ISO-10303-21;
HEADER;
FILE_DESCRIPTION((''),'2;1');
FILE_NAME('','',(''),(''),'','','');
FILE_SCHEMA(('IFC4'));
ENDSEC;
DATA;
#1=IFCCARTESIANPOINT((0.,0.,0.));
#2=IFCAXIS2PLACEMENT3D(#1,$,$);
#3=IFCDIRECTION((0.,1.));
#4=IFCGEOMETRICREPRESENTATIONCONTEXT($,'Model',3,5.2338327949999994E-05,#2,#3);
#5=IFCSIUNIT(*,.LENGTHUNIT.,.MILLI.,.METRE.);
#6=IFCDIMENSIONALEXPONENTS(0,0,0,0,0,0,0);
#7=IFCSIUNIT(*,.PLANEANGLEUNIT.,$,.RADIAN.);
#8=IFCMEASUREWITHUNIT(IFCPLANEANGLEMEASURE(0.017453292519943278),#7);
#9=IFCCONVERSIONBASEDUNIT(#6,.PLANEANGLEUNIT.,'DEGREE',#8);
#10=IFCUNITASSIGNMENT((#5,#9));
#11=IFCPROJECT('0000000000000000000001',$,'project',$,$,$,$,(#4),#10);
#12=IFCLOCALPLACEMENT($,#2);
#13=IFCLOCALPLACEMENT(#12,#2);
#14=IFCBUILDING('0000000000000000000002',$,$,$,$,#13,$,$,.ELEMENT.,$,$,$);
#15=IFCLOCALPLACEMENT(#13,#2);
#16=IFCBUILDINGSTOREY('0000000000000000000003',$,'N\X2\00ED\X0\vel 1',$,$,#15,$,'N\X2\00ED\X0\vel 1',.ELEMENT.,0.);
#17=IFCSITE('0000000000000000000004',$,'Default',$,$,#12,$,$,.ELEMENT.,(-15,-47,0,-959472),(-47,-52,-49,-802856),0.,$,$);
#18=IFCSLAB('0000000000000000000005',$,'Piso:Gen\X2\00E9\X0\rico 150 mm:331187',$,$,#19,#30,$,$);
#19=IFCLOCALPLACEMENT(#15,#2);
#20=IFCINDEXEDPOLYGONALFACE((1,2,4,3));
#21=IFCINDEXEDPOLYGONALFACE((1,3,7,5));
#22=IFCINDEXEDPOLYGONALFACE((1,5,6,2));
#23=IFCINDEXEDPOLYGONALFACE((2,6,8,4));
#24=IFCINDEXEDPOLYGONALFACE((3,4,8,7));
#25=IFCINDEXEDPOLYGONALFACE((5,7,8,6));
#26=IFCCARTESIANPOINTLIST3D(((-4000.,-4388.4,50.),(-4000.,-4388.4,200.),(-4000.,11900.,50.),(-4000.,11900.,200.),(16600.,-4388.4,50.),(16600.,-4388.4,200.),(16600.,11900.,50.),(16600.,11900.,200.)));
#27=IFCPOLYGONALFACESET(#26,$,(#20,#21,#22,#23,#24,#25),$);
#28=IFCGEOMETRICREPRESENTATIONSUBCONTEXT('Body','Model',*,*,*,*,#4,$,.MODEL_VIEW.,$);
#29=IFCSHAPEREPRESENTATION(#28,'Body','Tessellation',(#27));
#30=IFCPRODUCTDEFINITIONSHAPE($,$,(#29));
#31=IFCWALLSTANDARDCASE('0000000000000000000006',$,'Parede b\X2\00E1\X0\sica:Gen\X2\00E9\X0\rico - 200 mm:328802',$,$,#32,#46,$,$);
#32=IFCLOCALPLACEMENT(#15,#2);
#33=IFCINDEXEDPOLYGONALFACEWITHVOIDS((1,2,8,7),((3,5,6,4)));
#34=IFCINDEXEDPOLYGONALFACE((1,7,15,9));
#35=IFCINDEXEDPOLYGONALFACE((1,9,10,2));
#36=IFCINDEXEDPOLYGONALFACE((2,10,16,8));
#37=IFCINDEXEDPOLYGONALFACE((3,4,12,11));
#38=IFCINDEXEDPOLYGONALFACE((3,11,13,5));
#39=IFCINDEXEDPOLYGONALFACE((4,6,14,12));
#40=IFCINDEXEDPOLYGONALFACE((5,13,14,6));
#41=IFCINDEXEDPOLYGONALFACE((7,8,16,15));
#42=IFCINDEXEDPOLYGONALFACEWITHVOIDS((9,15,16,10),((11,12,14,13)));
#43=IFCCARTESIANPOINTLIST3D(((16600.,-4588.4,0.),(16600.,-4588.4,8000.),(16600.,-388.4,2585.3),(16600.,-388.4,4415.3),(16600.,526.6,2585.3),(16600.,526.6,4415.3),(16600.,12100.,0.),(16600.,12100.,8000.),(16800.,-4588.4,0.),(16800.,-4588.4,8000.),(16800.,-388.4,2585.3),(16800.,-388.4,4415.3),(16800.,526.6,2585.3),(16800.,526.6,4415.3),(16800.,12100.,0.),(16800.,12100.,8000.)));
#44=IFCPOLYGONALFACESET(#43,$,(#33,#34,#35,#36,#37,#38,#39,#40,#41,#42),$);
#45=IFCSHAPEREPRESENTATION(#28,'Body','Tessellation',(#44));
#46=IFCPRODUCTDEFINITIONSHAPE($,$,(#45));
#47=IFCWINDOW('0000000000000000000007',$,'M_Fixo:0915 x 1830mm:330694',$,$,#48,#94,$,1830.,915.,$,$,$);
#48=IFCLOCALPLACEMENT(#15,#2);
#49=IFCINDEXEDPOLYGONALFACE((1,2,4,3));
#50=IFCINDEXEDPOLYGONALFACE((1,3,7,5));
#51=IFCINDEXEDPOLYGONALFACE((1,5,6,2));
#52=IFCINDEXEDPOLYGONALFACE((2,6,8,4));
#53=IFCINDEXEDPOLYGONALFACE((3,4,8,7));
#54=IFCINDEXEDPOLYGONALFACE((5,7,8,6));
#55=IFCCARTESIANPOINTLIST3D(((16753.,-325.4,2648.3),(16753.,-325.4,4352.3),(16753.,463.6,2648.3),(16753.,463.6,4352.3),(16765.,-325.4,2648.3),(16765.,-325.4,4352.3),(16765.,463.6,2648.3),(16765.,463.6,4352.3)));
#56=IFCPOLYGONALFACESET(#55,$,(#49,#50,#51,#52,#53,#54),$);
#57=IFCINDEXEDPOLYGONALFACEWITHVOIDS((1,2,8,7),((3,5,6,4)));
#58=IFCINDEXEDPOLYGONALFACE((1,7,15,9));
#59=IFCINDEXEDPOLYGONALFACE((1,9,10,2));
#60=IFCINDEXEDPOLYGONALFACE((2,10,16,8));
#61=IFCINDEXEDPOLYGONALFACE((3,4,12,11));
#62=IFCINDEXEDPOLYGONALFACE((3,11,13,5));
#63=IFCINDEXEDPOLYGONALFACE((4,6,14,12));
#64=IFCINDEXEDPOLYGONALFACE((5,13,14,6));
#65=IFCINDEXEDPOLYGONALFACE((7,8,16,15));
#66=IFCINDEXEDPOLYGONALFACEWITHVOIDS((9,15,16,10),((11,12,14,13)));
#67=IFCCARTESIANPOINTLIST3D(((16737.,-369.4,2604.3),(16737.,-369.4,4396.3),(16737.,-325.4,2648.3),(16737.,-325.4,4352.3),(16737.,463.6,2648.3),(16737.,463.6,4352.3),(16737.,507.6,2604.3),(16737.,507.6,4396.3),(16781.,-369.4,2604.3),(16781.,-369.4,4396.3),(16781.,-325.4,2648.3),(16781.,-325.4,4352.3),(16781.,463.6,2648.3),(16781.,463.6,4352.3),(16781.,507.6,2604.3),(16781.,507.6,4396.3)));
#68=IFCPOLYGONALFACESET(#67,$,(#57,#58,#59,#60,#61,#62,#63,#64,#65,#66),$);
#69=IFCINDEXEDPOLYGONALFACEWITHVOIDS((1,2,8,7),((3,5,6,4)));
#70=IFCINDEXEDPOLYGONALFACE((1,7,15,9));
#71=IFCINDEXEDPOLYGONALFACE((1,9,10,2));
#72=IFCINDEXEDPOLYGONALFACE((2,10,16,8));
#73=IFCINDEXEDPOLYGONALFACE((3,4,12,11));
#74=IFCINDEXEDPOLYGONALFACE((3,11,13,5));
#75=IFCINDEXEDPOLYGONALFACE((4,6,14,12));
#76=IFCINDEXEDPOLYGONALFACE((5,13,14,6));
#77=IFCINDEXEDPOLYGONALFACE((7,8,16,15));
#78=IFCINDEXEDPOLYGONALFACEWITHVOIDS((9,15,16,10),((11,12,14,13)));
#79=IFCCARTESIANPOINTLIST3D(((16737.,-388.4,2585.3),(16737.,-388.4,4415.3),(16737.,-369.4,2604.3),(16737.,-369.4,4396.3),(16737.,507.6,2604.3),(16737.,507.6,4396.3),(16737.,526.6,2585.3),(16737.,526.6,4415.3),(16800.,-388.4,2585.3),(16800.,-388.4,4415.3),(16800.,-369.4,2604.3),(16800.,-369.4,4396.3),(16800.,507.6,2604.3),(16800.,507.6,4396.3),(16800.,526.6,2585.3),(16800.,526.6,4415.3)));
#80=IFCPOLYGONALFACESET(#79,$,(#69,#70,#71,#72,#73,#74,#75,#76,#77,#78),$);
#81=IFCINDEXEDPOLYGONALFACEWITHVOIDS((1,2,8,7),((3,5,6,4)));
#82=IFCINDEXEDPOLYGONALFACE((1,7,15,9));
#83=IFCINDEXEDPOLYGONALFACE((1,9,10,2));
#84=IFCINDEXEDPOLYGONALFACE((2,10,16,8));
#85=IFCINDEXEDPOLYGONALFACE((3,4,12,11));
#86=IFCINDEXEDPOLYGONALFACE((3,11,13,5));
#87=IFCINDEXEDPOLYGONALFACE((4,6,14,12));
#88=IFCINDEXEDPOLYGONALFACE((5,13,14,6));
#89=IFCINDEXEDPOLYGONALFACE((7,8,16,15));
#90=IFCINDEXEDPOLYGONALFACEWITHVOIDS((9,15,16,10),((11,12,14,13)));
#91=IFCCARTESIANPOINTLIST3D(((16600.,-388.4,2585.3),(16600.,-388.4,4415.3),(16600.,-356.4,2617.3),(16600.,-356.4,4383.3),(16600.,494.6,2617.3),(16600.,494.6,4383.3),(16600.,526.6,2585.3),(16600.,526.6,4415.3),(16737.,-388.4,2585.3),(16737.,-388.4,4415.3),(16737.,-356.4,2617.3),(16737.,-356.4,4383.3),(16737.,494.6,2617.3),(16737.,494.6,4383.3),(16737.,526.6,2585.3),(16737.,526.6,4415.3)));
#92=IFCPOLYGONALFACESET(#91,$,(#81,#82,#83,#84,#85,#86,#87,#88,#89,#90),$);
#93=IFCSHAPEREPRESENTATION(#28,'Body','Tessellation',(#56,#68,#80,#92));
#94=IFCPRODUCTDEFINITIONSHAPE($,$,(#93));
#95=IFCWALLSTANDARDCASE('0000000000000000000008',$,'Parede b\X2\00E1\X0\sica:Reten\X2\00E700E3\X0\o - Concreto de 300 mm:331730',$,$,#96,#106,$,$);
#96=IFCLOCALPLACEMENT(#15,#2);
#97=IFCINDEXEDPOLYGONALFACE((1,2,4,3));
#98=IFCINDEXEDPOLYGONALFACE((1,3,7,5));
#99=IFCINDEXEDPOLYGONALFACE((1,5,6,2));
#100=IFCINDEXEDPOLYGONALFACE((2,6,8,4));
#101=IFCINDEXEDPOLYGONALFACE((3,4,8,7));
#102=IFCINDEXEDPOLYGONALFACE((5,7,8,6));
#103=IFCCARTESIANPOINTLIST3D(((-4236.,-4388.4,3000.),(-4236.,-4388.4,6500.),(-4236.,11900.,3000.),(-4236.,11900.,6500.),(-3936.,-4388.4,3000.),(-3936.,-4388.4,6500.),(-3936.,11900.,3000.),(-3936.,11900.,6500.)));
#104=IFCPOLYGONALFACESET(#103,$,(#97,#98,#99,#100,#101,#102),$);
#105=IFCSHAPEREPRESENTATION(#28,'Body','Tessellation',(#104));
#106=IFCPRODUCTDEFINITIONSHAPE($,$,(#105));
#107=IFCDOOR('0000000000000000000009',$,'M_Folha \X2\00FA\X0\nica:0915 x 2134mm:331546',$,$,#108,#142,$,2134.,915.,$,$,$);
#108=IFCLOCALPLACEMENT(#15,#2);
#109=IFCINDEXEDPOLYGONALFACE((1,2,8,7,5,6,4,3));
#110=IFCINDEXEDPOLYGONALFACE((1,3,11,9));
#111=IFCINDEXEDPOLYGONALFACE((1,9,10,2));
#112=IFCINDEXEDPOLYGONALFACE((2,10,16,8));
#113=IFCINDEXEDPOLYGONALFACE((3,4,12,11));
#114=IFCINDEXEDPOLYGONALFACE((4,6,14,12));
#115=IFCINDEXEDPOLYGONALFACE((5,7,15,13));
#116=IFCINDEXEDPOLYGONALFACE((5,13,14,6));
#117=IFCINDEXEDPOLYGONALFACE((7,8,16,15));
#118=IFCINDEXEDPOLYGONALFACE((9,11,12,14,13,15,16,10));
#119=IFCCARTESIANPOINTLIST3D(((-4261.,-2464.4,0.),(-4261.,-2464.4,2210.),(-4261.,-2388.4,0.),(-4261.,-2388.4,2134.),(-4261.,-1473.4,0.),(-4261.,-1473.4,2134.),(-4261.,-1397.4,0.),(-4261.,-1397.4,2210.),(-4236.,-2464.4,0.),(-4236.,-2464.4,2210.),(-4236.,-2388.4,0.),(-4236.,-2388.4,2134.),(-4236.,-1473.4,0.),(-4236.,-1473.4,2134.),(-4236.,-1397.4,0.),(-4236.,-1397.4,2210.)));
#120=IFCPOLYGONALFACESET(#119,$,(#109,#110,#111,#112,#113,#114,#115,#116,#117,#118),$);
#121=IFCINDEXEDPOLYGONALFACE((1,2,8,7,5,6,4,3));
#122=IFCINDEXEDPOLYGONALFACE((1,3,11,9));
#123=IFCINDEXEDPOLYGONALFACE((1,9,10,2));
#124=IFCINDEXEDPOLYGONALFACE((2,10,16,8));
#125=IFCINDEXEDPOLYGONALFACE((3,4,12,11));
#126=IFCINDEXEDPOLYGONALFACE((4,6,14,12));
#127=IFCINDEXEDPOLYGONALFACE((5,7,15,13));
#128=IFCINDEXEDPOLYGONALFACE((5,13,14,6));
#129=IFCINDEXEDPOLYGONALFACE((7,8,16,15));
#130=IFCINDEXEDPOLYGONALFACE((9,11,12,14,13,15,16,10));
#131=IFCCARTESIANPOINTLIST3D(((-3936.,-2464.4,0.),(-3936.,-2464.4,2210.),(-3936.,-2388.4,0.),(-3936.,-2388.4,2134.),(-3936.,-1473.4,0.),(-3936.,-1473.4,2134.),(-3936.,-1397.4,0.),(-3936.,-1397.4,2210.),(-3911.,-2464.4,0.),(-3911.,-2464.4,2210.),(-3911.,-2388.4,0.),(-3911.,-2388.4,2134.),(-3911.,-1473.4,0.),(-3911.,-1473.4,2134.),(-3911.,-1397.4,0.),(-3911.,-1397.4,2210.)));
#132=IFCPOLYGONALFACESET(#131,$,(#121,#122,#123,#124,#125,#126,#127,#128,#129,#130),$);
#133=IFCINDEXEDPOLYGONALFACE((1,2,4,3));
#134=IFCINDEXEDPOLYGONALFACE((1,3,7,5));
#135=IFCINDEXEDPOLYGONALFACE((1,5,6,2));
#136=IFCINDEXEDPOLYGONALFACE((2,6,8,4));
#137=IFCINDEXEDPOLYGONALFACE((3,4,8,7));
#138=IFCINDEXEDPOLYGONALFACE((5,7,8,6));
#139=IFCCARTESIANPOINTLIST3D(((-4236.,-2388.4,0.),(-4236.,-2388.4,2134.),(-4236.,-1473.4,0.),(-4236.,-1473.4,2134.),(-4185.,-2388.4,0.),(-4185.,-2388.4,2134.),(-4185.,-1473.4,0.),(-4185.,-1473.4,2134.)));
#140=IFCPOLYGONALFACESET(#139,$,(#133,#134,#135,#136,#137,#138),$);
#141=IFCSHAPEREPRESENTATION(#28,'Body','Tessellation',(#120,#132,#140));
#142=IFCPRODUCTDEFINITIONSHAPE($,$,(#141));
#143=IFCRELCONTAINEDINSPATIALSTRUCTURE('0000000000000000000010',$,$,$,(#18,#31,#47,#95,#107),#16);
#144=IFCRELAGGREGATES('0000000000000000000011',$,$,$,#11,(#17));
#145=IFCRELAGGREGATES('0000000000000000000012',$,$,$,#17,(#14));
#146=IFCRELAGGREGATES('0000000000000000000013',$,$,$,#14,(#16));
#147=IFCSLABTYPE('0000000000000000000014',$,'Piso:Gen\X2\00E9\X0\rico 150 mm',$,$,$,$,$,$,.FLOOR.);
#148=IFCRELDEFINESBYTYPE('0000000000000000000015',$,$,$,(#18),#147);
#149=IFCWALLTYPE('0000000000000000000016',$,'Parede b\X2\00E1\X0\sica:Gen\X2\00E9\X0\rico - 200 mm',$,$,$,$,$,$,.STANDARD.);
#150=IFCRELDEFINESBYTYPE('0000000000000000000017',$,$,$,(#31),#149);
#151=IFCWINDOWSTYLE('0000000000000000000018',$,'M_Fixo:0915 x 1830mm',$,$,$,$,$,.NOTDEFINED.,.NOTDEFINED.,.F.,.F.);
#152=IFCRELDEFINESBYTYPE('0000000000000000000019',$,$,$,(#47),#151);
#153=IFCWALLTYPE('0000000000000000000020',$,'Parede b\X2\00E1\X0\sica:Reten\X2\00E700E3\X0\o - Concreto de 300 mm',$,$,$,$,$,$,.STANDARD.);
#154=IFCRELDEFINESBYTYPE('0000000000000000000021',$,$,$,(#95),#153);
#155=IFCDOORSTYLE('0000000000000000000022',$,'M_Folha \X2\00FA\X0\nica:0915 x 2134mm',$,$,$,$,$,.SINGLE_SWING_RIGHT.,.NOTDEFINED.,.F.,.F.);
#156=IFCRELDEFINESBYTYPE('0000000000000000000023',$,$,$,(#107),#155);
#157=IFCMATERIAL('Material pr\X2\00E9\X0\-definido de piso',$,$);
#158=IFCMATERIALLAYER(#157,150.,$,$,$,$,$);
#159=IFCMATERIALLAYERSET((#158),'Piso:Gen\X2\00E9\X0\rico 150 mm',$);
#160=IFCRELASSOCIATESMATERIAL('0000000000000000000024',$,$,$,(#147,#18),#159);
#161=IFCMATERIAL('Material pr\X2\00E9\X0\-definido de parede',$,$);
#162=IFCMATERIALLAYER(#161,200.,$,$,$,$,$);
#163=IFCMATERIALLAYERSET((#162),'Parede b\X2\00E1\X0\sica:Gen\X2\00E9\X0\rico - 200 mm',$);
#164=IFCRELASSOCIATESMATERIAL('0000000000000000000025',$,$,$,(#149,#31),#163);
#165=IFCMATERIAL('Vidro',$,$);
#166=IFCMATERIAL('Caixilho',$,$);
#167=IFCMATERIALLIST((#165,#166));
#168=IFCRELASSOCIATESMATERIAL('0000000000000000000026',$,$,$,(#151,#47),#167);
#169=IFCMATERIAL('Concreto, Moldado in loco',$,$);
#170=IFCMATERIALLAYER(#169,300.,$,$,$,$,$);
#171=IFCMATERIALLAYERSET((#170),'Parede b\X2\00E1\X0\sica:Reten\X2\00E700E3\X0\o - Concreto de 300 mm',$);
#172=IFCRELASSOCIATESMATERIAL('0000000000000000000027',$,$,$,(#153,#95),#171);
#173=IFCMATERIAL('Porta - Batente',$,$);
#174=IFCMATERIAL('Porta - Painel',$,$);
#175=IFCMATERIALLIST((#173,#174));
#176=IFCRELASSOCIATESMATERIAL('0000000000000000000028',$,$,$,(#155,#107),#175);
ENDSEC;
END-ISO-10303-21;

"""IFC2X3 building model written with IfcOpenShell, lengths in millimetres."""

from ifc_helpers import new_model, entity, si_unit, converted_unit, direction, frame, frame_2d, origin, place, context, subcontext, project, spatial, polyline, rectangle, outline, extrude, source, transform, mapped, material, material_list, layer, layer_set, layer_usage, type_object, type_shapes, element, fill, save


model = new_model("IFC2X3")

# Units and contexts
model_context = context("Model", 3, precision=5.2338327949999994e-05, world=origin(), true_north=direction((0.0, 1.0)))
body_context = subcontext(model_context, "Body", "Model", "MODEL_VIEW")
ifc_project = project(units=[si_unit("LENGTHUNIT", "METRE", prefix="MILLI"), converted_unit("PLANEANGLEUNIT", "DEGREE", entity("IfcPlaneAngleMeasure", 0.017453292519943278), si_unit("PLANEANGLEUNIT", "RADIAN"), dimensions=[0, 0, 0, 0, 0, 0, 0])], contexts=[model_context])

# Site, building, storey
site_placement = place(None, origin())
site = spatial("IfcSite", under=ifc_project, at=site_placement, Name="Default", CompositionType="ELEMENT", RefLatitude=(-15, -47, 0, -959472), RefLongitude=(-47, -52, -49, -802856), RefElevation=0.0)
building_placement = place(site_placement, origin())
building = spatial("IfcBuilding", under=site, at=building_placement, CompositionType="ELEMENT")
storey_placement = place(building_placement, origin())
storey = spatial("IfcBuildingStorey", under=building, at=storey_placement, Name="Nível 1", LongName="Nível 1", CompositionType="ELEMENT", Elevation=0.0)

# Slab
ifc_material_1 = material(Name="Material pré-definido de piso")
ifc_layer_1 = layer(ifc_material_1, 150.0)
ifc_layer_set_1 = layer_set([ifc_layer_1], Name="Piso:Genérico 150 mm")
ifc_layer_usage_1 = layer_usage(ifc_layer_set_1, "AXIS3", "POSITIVE", 0.0)
slab_type = type_object("IfcSlabType", Name="Piso:Genérico 150 mm", PredefinedType="FLOOR", material=ifc_layer_set_1)
slab_placement = place(storey_placement, origin())
element("IfcSlab", 1, at=slab_placement, inside=storey, type_object=slab_type, material=ifc_layer_usage_1, Name="Piso:Genérico 150 mm:331187", context=body_context, shape_type="SweptSolid", body=[
    extrude(rectangle(XDim=16288.4, YDim=20600.0, at=frame_2d((0.0, 0.0), x_axis=(1.0, 0.0))), frame((6300.0, 3755.8, 200.0), z_axis=(0.0, 0.0, -1.0), x_axis=(0.0, 1.0, 0.0)), (0.0, 0.0, 1.0), 150.0),
])

# Wall, opening, window
ifc_material_2 = material(Name="Material pré-definido de parede")
ifc_layer_2 = layer(ifc_material_2, 200.0)
ifc_layer_set_2 = layer_set([ifc_layer_2], Name="Parede básica:Genérico - 200 mm")
ifc_layer_usage_2 = layer_usage(ifc_layer_set_2, "AXIS2", "NEGATIVE", 100.0)
wall_type_1 = type_object("IfcWallType", Name="Parede básica:Genérico - 200 mm", PredefinedType="STANDARD", material=ifc_layer_set_2)
wall_1_placement = place(storey_placement, frame((16700.0, -4588.4, 0.0), z_axis=(0.0, 0.0, 1.0), x_axis=(0.0, 1.0, 0.0)))
wall_1 = element("IfcWallStandardCase", 2, at=wall_1_placement, inside=storey, type_object=wall_type_1, material=ifc_layer_usage_2, Name="Parede básica:Genérico - 200 mm:328802", context=body_context, shape_type="SweptSolid", body=[
    extrude(rectangle(XDim=16688.4, YDim=200.0, at=frame_2d((8344.2, 0.0), x_axis=(-1.0, 0.0))), origin(), (0.0, 0.0, 1.0), 8000.0),
])
opening_1_placement = place(wall_1_placement, frame((5115.0, 100.0, 2585.3)))
opening_1 = element("IfcOpeningElement", 3, at=opening_1_placement, cuts=wall_1, ObjectType="Opening", context=body_context, shape_type="SweptSolid", body=[
    extrude(rectangle(XDim=1830.0, YDim=915.0, at=frame_2d((915.0, 457.5), x_axis=(1.0, 0.0))), frame((0.0, 0.0, 0.0), z_axis=(0.0, -1.0, 0.0), x_axis=(0.0, 0.0, 1.0)), (0.0, 0.0, 1.0), 200.0),
])
ifc_material_3 = material(Name="Vidro")
ifc_material_4 = material(Name="Caixilho")
ifc_material_list_1 = material_list([ifc_material_3, ifc_material_4])
window_style = type_object("IfcWindowStyle", Name="M_Fixo:0915 x 1830mm", ConstructionType="NOTDEFINED", OperationType="NOTDEFINED", ParameterTakesPrecedence=False, Sizeable=False, material=ifc_material_list_1)
shared_shape_1 = source(origin(), body_context, "Body", "SweptSolid", [
    extrude(rectangle(XDim=12.0, YDim=789.0, at=frame_2d((0.0, 0.0), x_axis=(1.0, 0.0))), frame((457.5, 159.0, 63.0), z_axis=(0.0, 0.0, 1.0), x_axis=(0.0, -1.0, 0.0)), (0.0, 0.0, 1.0), 1704.0),
    extrude(outline(polyline([(-438.5, -896.0), (438.5, -896.0), (438.5, 896.0), (-438.5, 896.0), (-438.5, -896.0)]), holes=[polyline([(-394.5, -852.0), (-394.5, 852.0), (394.5, 852.0), (394.5, -852.0), (-394.5, -852.0)])]), frame((457.5, 137.0, 915.0), z_axis=(0.0, 1.0, 0.0), x_axis=(1.0, 0.0, 0.0)), (0.0, 0.0, 1.0), 44.0),
    extrude(outline(polyline([(-457.5, -915.0), (457.5, -915.0), (457.5, 915.0), (-457.5, 915.0), (-457.5, -915.0)]), holes=[polyline([(-438.5, -896.0), (-438.5, 896.0), (438.5, 896.0), (438.5, -896.0), (-438.5, -896.0)])]), frame((457.5, 137.0, 915.0), z_axis=(0.0, 1.0, 0.0), x_axis=(1.0, 0.0, 0.0)), (0.0, 0.0, 1.0), 63.0),
    extrude(outline(polyline([(-457.5, -915.0), (457.5, -915.0), (457.5, 915.0), (-457.5, 915.0), (-457.5, -915.0)]), holes=[polyline([(-425.5, -883.0), (-425.5, 883.0), (425.5, 883.0), (425.5, -883.0), (-425.5, -883.0)])]), frame((457.5, 0.0, 915.0), z_axis=(0.0, 1.0, 0.0), x_axis=(1.0, 0.0, 0.0)), (0.0, 0.0, 1.0), 137.0),
])
type_shapes(window_style, [shared_shape_1])
window_placement = place(opening_1_placement, frame((0.0, 0.0, 0.0), z_axis=(0.0, 0.0, 1.0), x_axis=(-1.0, 0.0, 0.0)))
window = element("IfcWindow", 4, at=window_placement, inside=storey, type_object=window_style, material=ifc_material_list_1, Name="M_Fixo:0915 x 1830mm:330694", OverallHeight=1830.0, OverallWidth=915.0, context=body_context, shape_type="MappedRepresentation", body=[
    mapped(shared_shape_1, transform((0.0, 0.0, 0.0), scale=1.0)),
])
fill(opening_1, window)

# Wall, openings, door
ifc_material_5 = material(Name="Concreto, Moldado in loco")
ifc_layer_3 = layer(ifc_material_5, 300.0)
ifc_layer_set_3 = layer_set([ifc_layer_3], Name="Parede básica:Retenção - Concreto de 300 mm")
ifc_layer_usage_3 = layer_usage(ifc_layer_set_3, "AXIS2", "NEGATIVE", 150.0)
wall_type_2 = type_object("IfcWallType", Name="Parede básica:Retenção - Concreto de 300 mm", PredefinedType="STANDARD", material=ifc_layer_set_3)
wall_2_placement = place(storey_placement, frame((-4086.0, 11900.0, 3000.0), z_axis=(0.0, 0.0, 1.0), x_axis=(0.0, -1.0, 0.0)))
wall_2 = element("IfcWallStandardCase", 5, at=wall_2_placement, inside=storey, type_object=wall_type_2, material=ifc_layer_usage_3, Name="Parede básica:Retenção - Concreto de 300 mm:331730", context=body_context, shape_type="SweptSolid", body=[
    extrude(rectangle(XDim=16288.4, YDim=300.0, at=frame_2d((8144.2, 0.0), x_axis=(-1.0, 0.0))), origin(), (0.0, 0.0, 1.0), 3500.0),
])
opening_2_placement = place(wall_2_placement, frame((14288.4, 150.0, -3000.0)))
opening_2 = element("IfcOpeningElement", 6, at=opening_2_placement, cuts=wall_2, ObjectType="Opening", context=body_context, shape_type="SweptSolid", body=[
    extrude(rectangle(XDim=915.0, YDim=2134.0, at=frame_2d((1067.0, 457.5), x_axis=(0.0, 1.0))), frame((0.0, 0.0, 0.0), z_axis=(0.0, -1.0, 0.0), x_axis=(0.0, 0.0, 1.0)), (0.0, 0.0, 1.0), 300.0),
])
opening_3_placement = place(wall_2_placement, frame((11900.0, 4086.0, -3000.0), z_axis=(0.0, 0.0, 1.0), x_axis=(0.0, 1.0, 0.0)))
element("IfcOpeningElement", 7, at=opening_3_placement, cuts=wall_2, ObjectType="Opening", context=body_context, shape_type="SweptSolid", body=[
    extrude(rectangle(XDim=2134.0, YDim=915.0, at=frame_2d((0.0, 0.0), x_axis=(0.0, 1.0))), frame((-5460.0, -1930.9, 1067.0), z_axis=(1.0, 0.0, 0.0), x_axis=(0.0, 1.0, 0.0)), (0.0, 0.0, 1.0), 3048.0),
])
ifc_material_6 = material(Name="Porta - Batente")
ifc_material_7 = material(Name="Porta - Painel")
ifc_material_list_2 = material_list([ifc_material_6, ifc_material_7])
door_style = type_object("IfcDoorStyle", Name="M_Folha única:0915 x 2134mm", ConstructionType="NOTDEFINED", OperationType="SINGLE_SWING_RIGHT", ParameterTakesPrecedence=False, Sizeable=False, material=ifc_material_list_2)
shared_shape_2 = source(origin(), body_context, "Body", "SweptSolid", [
    extrude(outline(polyline([(-533.5, -1124.0), (533.5, -1124.0), (533.5, 1086.0), (457.5, 1086.0), (457.5, -1048.0), (-457.5, -1048.0), (-457.5, 1086.0), (-533.5, 1086.0), (-533.5, -1124.0)])), frame((457.5, 300.0, 1086.0), z_axis=(0.0, 1.0, 0.0), x_axis=(1.0, 0.0, 0.0)), (0.0, 0.0, 1.0), 25.0),
    extrude(outline(polyline([(-1124.0, -533.5), (1086.0, -533.5), (1086.0, -457.5), (-1048.0, -457.5), (-1048.0, 457.5), (1086.0, 457.5), (1086.0, 533.5), (-1124.0, 533.5), (-1124.0, -533.5)])), frame((457.5, -25.0, 1086.0), z_axis=(0.0, 1.0, 0.0), x_axis=(0.0, 0.0, -1.0)), (0.0, 0.0, 1.0), 25.0),
    extrude(rectangle(XDim=51.0, YDim=915.0, at=frame_2d((0.0, 0.0), x_axis=(1.0, 0.0))), frame((457.5, 274.5, 0.0), z_axis=(0.0, 0.0, 1.0), x_axis=(0.0, 1.0, 0.0)), (0.0, 0.0, 1.0), 2134.0),
])
type_shapes(door_style, [shared_shape_2])
door_placement = place(opening_2_placement, frame((0.0, 0.0, 0.0), z_axis=(0.0, 0.0, 1.0), x_axis=(-1.0, 0.0, 0.0)))
door = element("IfcDoor", 8, at=door_placement, inside=storey, type_object=door_style, material=ifc_material_list_2, Name="M_Folha única:0915 x 2134mm:331546", OverallHeight=2134.0, OverallWidth=915.0, context=body_context, shape_type="MappedRepresentation", body=[
    mapped(shared_shape_2, transform((0.0, 0.0, 0.0), scale=1.0)),
])
fill(opening_2, door)

save(model, "model.ifc")
